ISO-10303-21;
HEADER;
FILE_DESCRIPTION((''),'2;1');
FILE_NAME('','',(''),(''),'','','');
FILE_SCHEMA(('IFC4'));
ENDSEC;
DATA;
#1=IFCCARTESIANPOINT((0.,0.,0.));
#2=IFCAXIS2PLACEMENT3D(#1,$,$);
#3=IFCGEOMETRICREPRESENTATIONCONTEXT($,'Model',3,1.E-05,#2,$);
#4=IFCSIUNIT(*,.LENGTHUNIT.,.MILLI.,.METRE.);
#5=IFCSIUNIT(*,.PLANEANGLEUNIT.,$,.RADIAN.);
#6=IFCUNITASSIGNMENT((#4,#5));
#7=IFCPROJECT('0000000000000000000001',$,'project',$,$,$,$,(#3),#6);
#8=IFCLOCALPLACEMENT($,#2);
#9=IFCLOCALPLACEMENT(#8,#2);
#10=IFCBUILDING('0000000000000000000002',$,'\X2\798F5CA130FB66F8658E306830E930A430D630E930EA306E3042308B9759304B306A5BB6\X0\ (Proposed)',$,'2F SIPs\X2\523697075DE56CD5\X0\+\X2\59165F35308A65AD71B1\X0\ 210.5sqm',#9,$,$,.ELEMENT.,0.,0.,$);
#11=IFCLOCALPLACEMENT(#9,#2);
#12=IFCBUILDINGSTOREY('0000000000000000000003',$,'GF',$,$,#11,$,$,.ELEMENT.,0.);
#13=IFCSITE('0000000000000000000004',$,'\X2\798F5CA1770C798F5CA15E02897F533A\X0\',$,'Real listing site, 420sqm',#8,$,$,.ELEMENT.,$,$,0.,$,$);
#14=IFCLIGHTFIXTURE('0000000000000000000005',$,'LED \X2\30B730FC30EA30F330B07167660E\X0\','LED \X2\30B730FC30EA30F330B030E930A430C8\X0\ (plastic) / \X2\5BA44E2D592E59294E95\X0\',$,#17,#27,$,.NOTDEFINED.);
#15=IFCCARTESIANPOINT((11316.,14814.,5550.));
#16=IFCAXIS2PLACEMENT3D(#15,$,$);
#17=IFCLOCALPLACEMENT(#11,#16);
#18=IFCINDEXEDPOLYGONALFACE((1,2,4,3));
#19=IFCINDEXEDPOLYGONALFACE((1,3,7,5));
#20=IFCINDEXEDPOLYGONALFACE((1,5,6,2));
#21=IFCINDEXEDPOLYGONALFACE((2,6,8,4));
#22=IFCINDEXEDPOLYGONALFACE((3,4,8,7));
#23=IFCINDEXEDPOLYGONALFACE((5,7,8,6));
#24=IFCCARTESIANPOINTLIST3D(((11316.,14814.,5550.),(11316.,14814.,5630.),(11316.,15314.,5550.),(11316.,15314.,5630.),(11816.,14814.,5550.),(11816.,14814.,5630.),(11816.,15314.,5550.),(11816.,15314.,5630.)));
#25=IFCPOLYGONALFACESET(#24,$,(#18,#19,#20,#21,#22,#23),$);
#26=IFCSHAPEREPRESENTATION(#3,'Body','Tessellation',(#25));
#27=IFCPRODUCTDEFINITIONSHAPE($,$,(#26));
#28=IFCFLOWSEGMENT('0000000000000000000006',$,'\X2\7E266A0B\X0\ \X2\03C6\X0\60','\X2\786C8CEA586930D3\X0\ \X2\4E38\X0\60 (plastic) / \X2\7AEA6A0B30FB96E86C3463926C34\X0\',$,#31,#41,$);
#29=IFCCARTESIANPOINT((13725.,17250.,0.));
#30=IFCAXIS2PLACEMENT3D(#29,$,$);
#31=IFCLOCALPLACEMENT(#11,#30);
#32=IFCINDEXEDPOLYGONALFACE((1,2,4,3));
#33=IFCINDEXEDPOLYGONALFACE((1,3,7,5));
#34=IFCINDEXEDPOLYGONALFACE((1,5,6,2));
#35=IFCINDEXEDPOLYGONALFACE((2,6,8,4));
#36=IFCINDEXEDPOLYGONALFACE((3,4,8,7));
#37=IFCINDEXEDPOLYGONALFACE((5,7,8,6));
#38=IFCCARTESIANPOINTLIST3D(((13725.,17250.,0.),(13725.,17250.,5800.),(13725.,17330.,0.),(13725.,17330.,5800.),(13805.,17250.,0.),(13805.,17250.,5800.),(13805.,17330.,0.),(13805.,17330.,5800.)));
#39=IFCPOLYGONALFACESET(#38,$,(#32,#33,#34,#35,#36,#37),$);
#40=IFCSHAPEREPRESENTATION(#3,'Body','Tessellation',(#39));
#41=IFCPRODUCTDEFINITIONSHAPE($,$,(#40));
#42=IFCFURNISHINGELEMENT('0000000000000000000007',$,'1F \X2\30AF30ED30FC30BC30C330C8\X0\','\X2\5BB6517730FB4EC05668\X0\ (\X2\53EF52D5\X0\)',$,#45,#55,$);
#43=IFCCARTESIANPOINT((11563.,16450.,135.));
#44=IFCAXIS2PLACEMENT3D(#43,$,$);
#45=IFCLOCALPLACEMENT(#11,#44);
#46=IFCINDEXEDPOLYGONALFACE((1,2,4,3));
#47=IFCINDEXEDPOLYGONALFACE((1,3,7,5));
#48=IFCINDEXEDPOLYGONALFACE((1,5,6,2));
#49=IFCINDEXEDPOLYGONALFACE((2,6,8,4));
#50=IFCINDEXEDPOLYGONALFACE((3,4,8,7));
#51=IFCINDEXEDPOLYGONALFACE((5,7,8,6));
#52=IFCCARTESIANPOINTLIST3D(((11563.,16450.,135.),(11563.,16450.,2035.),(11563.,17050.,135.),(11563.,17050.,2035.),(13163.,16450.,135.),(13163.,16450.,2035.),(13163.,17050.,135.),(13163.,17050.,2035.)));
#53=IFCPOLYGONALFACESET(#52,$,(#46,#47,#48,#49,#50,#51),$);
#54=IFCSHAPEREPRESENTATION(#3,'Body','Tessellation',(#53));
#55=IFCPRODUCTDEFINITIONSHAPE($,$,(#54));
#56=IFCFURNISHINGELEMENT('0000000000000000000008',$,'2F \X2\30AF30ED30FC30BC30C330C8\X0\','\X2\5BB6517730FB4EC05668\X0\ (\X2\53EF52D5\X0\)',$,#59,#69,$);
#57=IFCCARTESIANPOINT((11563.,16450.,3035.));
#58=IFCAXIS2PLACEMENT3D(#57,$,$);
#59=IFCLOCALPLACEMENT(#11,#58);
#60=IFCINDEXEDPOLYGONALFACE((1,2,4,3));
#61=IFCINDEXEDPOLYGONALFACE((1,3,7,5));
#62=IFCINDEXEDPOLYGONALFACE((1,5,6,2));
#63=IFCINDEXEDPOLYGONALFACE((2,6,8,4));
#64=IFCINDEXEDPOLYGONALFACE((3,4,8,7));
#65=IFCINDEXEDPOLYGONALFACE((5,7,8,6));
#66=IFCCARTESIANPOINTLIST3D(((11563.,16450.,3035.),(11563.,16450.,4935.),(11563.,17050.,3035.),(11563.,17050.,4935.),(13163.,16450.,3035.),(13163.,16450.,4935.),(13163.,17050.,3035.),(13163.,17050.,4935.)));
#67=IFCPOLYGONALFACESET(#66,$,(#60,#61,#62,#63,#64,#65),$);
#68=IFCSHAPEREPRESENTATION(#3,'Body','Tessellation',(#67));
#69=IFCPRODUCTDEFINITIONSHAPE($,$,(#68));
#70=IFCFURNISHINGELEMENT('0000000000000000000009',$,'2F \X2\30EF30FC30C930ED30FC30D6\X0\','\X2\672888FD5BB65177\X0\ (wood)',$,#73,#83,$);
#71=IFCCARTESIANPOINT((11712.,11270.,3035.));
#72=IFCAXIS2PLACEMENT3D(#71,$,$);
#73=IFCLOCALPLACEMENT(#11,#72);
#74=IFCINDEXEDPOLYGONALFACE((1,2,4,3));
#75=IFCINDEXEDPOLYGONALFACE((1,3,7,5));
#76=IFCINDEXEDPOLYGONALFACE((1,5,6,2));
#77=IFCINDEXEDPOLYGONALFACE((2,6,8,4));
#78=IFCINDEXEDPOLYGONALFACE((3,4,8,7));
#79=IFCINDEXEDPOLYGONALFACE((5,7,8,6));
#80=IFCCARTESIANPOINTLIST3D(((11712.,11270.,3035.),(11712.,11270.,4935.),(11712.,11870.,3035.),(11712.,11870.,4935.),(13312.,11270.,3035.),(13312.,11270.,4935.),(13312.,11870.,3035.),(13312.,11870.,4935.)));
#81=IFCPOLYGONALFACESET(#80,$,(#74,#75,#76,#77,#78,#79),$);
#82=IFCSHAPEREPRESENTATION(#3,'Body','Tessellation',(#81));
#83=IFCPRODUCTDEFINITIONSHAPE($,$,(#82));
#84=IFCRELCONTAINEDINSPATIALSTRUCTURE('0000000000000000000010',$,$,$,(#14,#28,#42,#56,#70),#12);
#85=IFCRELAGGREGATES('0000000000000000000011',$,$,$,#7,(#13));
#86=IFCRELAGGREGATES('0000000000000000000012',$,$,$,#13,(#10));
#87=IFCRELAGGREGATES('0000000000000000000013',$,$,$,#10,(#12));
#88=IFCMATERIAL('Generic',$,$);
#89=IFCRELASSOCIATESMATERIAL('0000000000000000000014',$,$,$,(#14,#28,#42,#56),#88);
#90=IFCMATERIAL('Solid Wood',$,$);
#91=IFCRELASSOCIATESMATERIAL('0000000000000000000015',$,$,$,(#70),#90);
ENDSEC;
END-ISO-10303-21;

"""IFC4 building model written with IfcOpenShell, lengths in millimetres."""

from ifc_helpers import new_model, si_unit, frame, frame_2d, origin, place, context, project, spatial, rectangle, extrude, material, element, save


model = new_model("IFC4")

# Units and contexts
model_context = context("Model", 3, precision=1e-05, world=origin())
ifc_project = project(units=[si_unit("LENGTHUNIT", "METRE", prefix="MILLI"), si_unit("PLANEANGLEUNIT", "RADIAN")], contexts=[model_context])

# Site, building, storey
site_placement = place(None, origin())
site = spatial("IfcSite", under=ifc_project, at=site_placement, Name="福岡県福岡市西区", ObjectType="Real listing site, 420sqm", CompositionType="ELEMENT", RefElevation=0.0)
building_placement = place(site_placement, origin())
building = spatial("IfcBuilding", under=site, at=building_placement, Name="福岡・書斎とライブラリのある静かな家 (Proposed)", ObjectType="2F SIPs制震工法+外張り断熱 210.5sqm", CompositionType="ELEMENT", ElevationOfRefHeight=0.0, ElevationOfTerrain=0.0)
storey_placement = place(building_placement, origin())
storey = spatial("IfcBuildingStorey", under=building, at=storey_placement, Name="GF", CompositionType="ELEMENT", Elevation=0.0)

# Shared definitions
ifc_material_1 = material(Name="Solid Wood")

# Shared definitions
ifc_material_2 = material(Name="Generic")

# Light fixture
light_fixture_1_placement = place(storey_placement, frame((11316.0, 14814.0, 5550.0)))
element("IfcLightFixture", 1, at=light_fixture_1_placement, inside=storey, material=ifc_material_2, Name="LED シーリング照明", Description="LED シーリングライト (plastic) / 室中央天井", PredefinedType="NOTDEFINED", context=model_context, shape_type="SweptSolid", body=[
    extrude(rectangle(XDim=500.0, YDim=500.0, at=frame_2d((250.0, 250.0))), frame((11316.0, 14814.0, 5550.0)), (0.0, 0.0, 1.0), 80.0),
])

# Flow segment
flow_segment_placement = place(storey_placement, frame((13725.0, 17250.0, 0.0)))
element("IfcFlowSegment", 2, at=flow_segment_placement, inside=storey, material=ifc_material_2, Name="縦樋 φ60", Description="硬質塩ビ 丸60 (plastic) / 竪樋・雨水排水", context=model_context, shape_type="SweptSolid", body=[
    extrude(rectangle(XDim=80.0, YDim=80.0, at=frame_2d((40.0, 40.0))), frame((13725.0, 17250.0, 0.0)), (0.0, 0.0, 1.0), 5800.0),
])

# Furnishing elements
furnishing_1_placement = place(storey_placement, frame((11563.0, 16450.0, 135.0)))
element("IfcFurnishingElement", 3, at=furnishing_1_placement, inside=storey, material=ifc_material_2, Name="1F クローゼット", Description="家具・什器 (可動)", context=model_context, shape_type="SweptSolid", body=[
    extrude(rectangle(XDim=1600.0, YDim=600.0, at=frame_2d((800.0, 300.0))), frame((11563.0, 16450.0, 135.0)), (0.0, 0.0, 1.0), 1900.0),
])
furnishing_2_placement = place(storey_placement, frame((11563.0, 16450.0, 3035.0)))
element("IfcFurnishingElement", 4, at=furnishing_2_placement, inside=storey, material=ifc_material_2, Name="2F クローゼット", Description="家具・什器 (可動)", context=model_context, shape_type="SweptSolid", body=[
    extrude(rectangle(XDim=1600.0, YDim=600.0, at=frame_2d((800.0, 300.0))), frame((11563.0, 16450.0, 3035.0)), (0.0, 0.0, 1.0), 1900.0),
])
furnishing_3_placement = place(storey_placement, frame((11712.0, 11270.0, 3035.0)))
element("IfcFurnishingElement", 5, at=furnishing_3_placement, inside=storey, material=ifc_material_1, Name="2F ワードローブ", Description="木製家具 (wood)", context=model_context, shape_type="SweptSolid", body=[
    extrude(rectangle(XDim=1600.0, YDim=600.0, at=frame_2d((800.0, 300.0))), frame((11712.0, 11270.0, 3035.0)), (0.0, 0.0, 1.0), 1900.0),
])

save(model, "model.ifc")
